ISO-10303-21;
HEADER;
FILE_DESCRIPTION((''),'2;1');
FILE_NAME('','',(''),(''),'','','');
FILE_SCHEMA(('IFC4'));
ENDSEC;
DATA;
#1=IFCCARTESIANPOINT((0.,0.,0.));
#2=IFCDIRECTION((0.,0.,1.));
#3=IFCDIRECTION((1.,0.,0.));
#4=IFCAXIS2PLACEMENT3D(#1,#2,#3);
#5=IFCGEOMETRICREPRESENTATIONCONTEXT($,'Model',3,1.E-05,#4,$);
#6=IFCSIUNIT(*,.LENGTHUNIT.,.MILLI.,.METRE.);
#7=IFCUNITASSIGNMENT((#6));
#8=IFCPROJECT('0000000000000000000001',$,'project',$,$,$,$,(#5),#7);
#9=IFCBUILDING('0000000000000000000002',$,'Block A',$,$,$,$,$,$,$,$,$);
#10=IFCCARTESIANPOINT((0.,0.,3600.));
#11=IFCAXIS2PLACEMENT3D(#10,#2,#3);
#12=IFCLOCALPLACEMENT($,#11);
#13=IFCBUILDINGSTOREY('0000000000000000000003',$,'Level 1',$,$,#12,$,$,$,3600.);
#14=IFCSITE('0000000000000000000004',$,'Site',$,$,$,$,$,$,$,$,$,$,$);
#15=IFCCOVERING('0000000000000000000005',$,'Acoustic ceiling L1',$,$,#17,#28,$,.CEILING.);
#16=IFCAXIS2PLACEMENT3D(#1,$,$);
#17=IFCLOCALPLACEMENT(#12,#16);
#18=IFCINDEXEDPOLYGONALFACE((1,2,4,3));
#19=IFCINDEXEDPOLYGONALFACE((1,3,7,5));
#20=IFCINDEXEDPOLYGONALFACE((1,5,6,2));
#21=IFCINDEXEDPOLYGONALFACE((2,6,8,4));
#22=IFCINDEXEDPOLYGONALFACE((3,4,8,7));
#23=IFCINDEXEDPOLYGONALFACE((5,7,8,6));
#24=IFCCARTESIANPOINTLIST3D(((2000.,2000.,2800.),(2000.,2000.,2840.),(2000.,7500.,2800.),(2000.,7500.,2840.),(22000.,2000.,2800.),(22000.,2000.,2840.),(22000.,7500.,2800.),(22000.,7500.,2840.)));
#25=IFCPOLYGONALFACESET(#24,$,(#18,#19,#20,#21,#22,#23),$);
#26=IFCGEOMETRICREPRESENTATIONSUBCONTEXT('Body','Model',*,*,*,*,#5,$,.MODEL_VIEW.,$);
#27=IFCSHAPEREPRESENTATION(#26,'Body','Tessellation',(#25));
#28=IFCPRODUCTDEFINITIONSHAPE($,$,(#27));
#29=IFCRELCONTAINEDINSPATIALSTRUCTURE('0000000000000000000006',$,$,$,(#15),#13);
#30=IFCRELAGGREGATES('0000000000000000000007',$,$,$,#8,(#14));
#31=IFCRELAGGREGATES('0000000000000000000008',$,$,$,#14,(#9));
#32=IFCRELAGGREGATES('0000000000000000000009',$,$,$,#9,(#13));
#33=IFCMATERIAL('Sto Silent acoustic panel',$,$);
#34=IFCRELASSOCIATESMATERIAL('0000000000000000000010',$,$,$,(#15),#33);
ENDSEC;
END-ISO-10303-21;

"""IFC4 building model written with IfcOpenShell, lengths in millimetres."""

from ifc_helpers import new_model, si_unit, frame, origin_with_axes, place, context, subcontext, project, spatial, indexed_curve, outline, extrude, material, element, save


model = new_model("IFC4")

# Units and contexts
model_context = context("Model", 3, precision=1e-05, world=origin_with_axes())
body_context = subcontext(model_context, "Body", "Model", "MODEL_VIEW")
ifc_project = project(units=[si_unit("LENGTHUNIT", "METRE", prefix="MILLI")], contexts=[model_context])

# Site, building, storey
site = spatial("IfcSite", under=ifc_project, Name="Site")
building = spatial("IfcBuilding", under=site, Name="Block A")
storey_placement = place(None, frame((0.0, 0.0, 3600.0), z_axis=(0.0, 0.0, 1.0), x_axis=(1.0, 0.0, 0.0)))
storey = spatial("IfcBuildingStorey", under=building, at=storey_placement, Name="Level 1", Elevation=3600.0)

# Covering
ifc_material_1 = material(Name="Sto Silent acoustic panel")
covering_placement = place(storey_placement, frame((0.0, 0.0, 2800.0), z_axis=(0.0, 0.0, 1.0), x_axis=(1.0, 0.0, 0.0)))
element("IfcCovering", 1, at=covering_placement, inside=storey, material=ifc_material_1, Name="Acoustic ceiling L1", PredefinedType="CEILING", context=body_context, shape_type="SweptSolid", body=[
    extrude(outline(indexed_curve([(2000.0, 2000.0), (22000.0, 2000.0), (22000.0, 7500.0), (2000.0, 7500.0), (2000.0, 2000.0)])), None, (0.0, 0.0, 1.0), 40.0),
])

save(model, "model.ifc")
